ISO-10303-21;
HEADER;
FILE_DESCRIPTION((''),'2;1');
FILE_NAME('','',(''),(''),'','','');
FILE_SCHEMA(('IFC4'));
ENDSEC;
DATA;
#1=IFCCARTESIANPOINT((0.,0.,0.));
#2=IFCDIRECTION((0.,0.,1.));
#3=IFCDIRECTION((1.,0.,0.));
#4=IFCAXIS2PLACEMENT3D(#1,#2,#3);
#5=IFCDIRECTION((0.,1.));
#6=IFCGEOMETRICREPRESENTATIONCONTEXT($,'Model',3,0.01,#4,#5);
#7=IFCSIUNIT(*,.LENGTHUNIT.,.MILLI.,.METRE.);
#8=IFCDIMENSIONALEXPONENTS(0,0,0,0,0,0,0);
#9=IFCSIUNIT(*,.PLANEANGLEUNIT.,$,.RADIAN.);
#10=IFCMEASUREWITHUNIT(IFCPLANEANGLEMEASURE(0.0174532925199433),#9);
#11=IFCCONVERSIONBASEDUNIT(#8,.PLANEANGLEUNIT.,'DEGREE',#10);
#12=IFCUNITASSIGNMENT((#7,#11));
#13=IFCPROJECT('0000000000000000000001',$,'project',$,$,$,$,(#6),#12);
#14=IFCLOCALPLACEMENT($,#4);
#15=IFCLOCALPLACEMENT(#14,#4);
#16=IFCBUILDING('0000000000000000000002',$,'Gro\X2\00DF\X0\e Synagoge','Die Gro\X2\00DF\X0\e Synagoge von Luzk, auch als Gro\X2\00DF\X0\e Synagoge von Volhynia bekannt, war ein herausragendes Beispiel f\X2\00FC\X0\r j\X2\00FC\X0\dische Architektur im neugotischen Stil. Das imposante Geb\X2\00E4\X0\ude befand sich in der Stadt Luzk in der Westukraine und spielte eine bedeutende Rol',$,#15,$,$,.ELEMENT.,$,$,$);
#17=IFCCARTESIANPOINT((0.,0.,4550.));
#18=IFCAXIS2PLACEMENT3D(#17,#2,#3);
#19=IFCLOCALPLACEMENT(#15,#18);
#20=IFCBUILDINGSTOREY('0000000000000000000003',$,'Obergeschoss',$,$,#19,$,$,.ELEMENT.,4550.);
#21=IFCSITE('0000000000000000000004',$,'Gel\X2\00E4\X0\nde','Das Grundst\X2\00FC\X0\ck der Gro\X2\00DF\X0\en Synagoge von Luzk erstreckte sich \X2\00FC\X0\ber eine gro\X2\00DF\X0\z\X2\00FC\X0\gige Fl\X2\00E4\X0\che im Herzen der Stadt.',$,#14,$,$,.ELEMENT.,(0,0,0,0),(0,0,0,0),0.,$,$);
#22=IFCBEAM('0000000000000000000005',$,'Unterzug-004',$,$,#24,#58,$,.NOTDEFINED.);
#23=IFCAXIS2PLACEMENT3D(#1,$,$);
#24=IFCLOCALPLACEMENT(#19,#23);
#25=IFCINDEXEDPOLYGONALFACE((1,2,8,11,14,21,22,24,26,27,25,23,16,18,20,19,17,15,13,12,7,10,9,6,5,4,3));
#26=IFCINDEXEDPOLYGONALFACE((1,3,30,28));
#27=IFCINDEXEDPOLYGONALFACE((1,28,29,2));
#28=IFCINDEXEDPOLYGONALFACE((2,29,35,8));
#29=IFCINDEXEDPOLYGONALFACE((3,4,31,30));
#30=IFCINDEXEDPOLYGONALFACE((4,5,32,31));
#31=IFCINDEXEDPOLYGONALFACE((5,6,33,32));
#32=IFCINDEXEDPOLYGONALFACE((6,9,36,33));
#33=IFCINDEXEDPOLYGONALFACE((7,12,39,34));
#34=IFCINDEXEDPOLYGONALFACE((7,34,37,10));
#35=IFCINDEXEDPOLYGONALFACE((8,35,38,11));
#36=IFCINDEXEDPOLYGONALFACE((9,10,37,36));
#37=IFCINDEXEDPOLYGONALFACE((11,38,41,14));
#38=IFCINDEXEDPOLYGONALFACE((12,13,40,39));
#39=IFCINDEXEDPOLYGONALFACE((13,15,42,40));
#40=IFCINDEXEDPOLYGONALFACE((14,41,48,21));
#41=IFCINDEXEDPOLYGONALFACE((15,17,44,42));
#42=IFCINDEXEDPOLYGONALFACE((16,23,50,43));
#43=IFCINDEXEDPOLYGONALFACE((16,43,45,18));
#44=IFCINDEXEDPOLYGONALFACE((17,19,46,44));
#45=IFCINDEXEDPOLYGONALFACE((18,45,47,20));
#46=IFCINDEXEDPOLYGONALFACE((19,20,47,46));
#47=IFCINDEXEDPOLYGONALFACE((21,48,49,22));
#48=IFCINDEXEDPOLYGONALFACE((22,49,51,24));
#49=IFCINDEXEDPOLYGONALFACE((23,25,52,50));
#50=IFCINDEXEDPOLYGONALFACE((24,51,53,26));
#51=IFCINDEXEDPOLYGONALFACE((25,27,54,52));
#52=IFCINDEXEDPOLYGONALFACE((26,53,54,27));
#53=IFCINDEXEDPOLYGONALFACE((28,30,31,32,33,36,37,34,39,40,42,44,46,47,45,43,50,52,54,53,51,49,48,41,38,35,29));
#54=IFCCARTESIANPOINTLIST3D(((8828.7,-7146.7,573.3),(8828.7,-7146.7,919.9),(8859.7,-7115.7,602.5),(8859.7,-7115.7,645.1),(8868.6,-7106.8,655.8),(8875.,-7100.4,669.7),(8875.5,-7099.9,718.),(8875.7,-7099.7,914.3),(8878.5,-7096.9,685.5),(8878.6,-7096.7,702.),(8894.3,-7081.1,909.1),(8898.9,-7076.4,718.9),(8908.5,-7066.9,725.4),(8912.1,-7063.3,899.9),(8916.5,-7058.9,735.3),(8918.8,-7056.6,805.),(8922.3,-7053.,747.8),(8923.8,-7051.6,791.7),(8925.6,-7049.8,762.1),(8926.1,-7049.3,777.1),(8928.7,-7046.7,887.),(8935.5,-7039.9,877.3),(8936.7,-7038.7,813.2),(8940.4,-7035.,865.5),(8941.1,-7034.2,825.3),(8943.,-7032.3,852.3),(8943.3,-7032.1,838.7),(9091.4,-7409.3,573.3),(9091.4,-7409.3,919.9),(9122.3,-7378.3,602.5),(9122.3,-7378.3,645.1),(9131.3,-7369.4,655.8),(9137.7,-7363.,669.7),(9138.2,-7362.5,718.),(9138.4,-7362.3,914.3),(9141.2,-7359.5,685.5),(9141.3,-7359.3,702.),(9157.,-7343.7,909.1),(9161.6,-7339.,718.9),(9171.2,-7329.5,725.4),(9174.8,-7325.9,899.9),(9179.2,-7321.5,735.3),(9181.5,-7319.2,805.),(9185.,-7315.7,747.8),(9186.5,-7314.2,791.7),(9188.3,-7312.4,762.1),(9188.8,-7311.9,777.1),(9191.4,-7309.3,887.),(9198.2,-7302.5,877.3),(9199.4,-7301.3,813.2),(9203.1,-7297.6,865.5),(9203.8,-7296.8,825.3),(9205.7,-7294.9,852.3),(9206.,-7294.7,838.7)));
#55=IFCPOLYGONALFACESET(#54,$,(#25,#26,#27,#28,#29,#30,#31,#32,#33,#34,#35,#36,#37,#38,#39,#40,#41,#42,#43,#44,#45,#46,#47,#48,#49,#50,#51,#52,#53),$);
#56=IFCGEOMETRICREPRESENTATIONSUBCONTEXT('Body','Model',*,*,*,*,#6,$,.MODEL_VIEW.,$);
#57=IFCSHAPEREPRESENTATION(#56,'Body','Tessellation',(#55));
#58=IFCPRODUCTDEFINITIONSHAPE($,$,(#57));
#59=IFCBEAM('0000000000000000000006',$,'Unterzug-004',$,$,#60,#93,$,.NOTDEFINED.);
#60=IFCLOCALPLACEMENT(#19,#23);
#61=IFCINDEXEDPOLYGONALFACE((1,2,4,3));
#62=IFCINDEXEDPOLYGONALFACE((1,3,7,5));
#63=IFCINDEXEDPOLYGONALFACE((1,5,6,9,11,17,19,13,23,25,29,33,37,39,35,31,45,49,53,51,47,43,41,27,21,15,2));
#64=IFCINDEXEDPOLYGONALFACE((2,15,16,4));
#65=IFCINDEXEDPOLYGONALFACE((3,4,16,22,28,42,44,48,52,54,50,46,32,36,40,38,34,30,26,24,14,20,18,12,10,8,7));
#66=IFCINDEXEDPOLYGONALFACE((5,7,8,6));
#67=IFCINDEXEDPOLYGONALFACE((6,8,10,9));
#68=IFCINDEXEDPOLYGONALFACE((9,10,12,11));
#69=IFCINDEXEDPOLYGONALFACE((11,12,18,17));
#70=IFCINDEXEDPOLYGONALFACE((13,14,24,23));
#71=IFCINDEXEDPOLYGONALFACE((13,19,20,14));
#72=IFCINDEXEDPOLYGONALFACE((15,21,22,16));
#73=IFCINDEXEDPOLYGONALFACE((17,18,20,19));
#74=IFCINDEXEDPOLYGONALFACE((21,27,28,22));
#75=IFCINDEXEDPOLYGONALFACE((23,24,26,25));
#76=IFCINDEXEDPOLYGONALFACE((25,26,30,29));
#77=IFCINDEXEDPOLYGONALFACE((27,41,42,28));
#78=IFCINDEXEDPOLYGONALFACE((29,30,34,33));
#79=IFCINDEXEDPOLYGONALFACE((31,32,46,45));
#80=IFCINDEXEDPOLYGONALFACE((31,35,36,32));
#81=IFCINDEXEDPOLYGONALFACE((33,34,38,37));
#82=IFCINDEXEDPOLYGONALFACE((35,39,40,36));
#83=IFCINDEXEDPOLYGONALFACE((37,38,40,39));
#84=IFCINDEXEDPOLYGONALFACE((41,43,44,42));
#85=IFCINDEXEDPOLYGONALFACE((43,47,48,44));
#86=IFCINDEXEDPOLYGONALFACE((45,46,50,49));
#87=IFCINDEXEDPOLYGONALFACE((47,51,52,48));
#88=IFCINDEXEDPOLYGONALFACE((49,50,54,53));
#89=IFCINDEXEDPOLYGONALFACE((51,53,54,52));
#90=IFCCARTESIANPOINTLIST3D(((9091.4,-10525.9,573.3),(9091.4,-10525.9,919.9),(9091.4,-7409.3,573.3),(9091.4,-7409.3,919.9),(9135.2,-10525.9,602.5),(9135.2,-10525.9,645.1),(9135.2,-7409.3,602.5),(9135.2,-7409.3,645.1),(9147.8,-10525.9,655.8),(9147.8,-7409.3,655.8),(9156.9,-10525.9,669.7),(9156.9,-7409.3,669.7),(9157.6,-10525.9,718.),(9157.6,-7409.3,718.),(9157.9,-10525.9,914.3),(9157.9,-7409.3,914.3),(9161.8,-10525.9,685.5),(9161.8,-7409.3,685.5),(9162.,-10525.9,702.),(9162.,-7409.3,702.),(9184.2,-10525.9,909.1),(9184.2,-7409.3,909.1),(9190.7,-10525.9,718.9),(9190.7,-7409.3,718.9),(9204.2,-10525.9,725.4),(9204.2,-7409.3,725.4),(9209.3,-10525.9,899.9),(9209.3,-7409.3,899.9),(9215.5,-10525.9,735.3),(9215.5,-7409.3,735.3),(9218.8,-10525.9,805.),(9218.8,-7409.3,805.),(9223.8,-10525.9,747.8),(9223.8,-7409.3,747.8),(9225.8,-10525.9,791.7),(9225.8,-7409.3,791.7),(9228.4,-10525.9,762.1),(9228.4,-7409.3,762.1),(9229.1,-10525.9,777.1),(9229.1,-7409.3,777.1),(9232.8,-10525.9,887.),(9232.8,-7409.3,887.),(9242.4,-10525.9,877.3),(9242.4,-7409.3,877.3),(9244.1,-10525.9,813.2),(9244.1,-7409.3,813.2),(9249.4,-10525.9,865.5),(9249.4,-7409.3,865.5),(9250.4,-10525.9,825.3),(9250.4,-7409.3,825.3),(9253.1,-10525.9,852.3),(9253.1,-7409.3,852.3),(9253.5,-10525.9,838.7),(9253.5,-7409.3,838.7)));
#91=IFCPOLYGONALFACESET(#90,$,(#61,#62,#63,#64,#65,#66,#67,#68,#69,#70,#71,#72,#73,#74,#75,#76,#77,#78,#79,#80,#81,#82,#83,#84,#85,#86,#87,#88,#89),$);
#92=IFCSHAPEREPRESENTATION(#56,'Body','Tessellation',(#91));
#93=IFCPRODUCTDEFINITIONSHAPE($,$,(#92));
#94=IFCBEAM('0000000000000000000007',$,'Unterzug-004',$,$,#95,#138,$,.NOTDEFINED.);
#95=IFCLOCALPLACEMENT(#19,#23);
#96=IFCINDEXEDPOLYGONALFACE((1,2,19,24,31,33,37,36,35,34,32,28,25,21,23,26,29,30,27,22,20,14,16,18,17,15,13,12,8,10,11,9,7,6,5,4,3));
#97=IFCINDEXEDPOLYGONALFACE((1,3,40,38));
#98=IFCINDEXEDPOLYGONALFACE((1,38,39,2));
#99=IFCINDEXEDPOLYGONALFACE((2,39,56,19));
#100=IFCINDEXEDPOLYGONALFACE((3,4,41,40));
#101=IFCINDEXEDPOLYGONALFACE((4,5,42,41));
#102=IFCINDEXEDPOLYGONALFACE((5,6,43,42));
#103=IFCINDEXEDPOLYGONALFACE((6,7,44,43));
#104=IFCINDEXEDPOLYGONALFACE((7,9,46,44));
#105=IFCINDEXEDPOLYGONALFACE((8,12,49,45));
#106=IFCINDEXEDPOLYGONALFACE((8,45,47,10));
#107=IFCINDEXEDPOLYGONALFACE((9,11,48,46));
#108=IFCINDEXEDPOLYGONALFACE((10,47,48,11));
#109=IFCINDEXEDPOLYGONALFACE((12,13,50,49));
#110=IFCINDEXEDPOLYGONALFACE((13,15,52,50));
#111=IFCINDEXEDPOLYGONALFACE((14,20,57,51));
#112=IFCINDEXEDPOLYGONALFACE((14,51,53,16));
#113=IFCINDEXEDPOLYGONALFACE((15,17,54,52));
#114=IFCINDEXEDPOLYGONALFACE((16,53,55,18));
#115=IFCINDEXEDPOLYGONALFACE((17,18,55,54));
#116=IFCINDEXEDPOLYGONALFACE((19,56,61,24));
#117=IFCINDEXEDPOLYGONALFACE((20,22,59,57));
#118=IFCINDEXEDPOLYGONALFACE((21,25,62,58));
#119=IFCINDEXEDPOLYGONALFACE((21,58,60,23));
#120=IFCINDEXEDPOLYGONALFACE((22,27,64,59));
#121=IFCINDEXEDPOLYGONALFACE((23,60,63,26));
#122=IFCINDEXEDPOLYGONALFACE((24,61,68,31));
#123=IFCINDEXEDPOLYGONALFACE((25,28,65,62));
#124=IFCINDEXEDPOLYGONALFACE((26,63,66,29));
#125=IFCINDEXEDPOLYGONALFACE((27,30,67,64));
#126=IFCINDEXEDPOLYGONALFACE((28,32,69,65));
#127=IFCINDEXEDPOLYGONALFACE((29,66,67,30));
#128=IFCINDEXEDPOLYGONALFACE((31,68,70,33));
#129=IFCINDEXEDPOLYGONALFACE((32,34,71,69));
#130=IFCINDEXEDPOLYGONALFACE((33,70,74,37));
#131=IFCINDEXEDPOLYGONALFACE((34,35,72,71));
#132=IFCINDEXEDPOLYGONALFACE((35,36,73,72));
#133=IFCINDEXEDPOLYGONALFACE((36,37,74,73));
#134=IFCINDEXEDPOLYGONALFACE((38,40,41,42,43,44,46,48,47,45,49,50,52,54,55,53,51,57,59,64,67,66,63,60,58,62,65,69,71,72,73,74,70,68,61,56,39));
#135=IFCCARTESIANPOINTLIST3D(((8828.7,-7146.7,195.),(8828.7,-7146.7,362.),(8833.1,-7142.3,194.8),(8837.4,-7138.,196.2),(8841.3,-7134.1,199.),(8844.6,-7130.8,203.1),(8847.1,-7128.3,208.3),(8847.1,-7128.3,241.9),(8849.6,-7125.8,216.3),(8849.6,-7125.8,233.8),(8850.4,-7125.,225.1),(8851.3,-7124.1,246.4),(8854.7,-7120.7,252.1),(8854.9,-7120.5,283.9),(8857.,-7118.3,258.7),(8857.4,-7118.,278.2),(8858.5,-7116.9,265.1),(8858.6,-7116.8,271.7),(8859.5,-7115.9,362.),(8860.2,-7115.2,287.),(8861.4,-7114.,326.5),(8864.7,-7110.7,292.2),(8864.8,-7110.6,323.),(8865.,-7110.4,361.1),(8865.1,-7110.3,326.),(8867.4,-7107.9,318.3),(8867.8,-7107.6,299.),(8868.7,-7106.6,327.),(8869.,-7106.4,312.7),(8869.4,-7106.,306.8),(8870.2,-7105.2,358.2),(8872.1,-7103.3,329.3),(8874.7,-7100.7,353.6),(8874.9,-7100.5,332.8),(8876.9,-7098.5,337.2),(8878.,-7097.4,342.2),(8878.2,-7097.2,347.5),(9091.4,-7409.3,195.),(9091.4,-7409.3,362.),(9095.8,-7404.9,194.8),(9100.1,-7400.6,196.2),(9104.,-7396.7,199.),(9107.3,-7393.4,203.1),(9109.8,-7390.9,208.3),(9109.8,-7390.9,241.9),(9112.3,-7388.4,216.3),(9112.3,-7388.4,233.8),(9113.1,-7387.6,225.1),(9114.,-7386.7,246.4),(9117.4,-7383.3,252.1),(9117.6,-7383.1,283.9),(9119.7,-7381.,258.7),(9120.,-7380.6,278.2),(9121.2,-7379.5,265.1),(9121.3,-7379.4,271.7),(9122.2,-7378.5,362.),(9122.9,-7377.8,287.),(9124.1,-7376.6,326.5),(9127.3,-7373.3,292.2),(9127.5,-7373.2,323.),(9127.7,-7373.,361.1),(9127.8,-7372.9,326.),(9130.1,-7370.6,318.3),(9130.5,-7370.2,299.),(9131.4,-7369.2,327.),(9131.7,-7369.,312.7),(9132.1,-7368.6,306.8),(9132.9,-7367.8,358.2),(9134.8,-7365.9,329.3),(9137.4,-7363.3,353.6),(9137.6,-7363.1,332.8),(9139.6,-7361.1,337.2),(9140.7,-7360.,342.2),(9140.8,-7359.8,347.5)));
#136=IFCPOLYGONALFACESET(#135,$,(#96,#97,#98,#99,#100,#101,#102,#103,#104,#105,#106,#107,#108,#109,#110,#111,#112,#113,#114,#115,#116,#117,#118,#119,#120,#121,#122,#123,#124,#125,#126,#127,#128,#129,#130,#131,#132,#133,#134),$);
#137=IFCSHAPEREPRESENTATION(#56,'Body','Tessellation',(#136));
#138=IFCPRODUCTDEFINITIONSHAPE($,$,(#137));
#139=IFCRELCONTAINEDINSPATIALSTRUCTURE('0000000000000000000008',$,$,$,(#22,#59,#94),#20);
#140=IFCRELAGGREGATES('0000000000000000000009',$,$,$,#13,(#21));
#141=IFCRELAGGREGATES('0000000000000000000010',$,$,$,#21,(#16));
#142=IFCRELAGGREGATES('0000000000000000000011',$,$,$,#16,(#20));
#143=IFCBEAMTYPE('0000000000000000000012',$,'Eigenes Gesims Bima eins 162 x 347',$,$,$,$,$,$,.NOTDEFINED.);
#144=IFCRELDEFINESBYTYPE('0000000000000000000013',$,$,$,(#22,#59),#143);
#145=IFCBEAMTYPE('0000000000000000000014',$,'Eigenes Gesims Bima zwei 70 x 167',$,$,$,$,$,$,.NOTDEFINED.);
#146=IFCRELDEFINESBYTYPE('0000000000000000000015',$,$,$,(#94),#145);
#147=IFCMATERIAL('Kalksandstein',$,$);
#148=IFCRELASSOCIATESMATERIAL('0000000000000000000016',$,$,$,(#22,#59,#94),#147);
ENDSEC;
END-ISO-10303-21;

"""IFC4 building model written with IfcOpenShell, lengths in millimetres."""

from ifc_helpers import new_model, entity, si_unit, converted_unit, direction, frame, origin_with_axes, place, context, subcontext, project, spatial, line, arc, indexed_curve, outline, extrude, material, material_profile, profile_set, type_object, element, save


model = new_model("IFC4")

# Units and contexts
model_context = context("Model", 3, precision=0.01, world=origin_with_axes(), true_north=direction((0.0, 1.0)))
body_context = subcontext(model_context, "Body", "Model", "MODEL_VIEW")
ifc_project = project(units=[si_unit("LENGTHUNIT", "METRE", prefix="MILLI"), converted_unit("PLANEANGLEUNIT", "DEGREE", entity("IfcPlaneAngleMeasure", 0.0174532925199433), si_unit("PLANEANGLEUNIT", "RADIAN"), dimensions=[0, 0, 0, 0, 0, 0, 0])], contexts=[model_context])

# Site, building, storey
site_placement = place(None, origin_with_axes())
site = spatial("IfcSite", under=ifc_project, at=site_placement, Name="Gelände", Description="Das Grundstück der Großen Synagoge von Luzk erstreckte sich über eine großzügige Fläche im Herzen der Stadt.", CompositionType="ELEMENT", RefLatitude=(0, 0, 0, 0), RefLongitude=(0, 0, 0, 0), RefElevation=0.0)
building_placement = place(site_placement, origin_with_axes())
building = spatial("IfcBuilding", under=site, at=building_placement, Name="Große Synagoge", Description="Die Große Synagoge von Luzk, auch als Große Synagoge von Volhynia bekannt, war ein herausragendes Beispiel für jüdische Architektur im neugotischen Stil. Das imposante Gebäude befand sich in der Stadt Luzk in der Westukraine und spielte eine bedeutende Rol", CompositionType="ELEMENT")
storey_placement = place(building_placement, frame((0.0, 0.0, 4550.0), z_axis=(0.0, 0.0, 1.0), x_axis=(1.0, 0.0, 0.0)))
storey = spatial("IfcBuildingStorey", under=building, at=storey_placement, Name="Obergeschoss", CompositionType="ELEMENT", Elevation=4550.0)

# Beams
ifc_material_1 = material(Name="Kalksandstein")
ifc_material_profile_1 = material_profile(ifc_material_1, outline(indexed_curve([(127.4, -114.9), (152.7, -106.7), (161.7, -67.6), (141.4, -32.9), (105.5, -14.9), (66.5, -5.6), (0.0, 0.0), (0.0, -346.6), (43.7, -317.4), (43.7, -274.8), (68.5, -242.5), (66.2, -201.9), (99.3, -201.0), (135.2, -165.1)], segments=[line(1, 2), arc(2, 3, 4), arc(4, 5, 6), line(6, 7, 8, 9, 10), arc(10, 11, 12), line(12, 13), arc(13, 14, 1)])), Name="Kalksandstein")
ifc_profile_set_1 = profile_set([ifc_material_profile_1], Name="Eigenes Gesims Bima eins")
beam_type_1 = type_object("IfcBeamType", Name="Eigenes Gesims Bima eins 162 x 347", PredefinedType="NOTDEFINED")
beam_1_placement = place(storey_placement, frame((9091.4, -7409.3, 919.9), z_axis=(0.0, 0.0, 1.0), x_axis=(0.706994, 0.707219, 0.0)))
element("IfcBeam", 1, at=beam_1_placement, inside=storey, type_object=beam_type_1, material=ifc_profile_set_1, Name="Unterzug-004", PredefinedType="NOTDEFINED", context=body_context, shape_type="SweptSolid", body=[
    extrude(outline(indexed_curve([(127.4, -114.9), (152.7, -106.7), (161.7, -67.6), (141.4, -32.9), (105.5, -14.9), (66.5, -5.6), (0.0, 0.0), (0.0, -346.6), (43.7, -317.4), (43.7, -274.8), (68.5, -242.5), (66.2, -201.9), (99.3, -201.0), (135.2, -165.1)], segments=[line(1, 2), arc(2, 3, 4), arc(4, 5, 6), line(6, 7, 8, 9, 10), arc(10, 11, 12), line(12, 13), arc(13, 14, 1)])), frame((0.0, 371.4, 0.0), z_axis=(0.0, -1.0, 0.0), x_axis=(1.0, 0.0, 0.0)), (0.0, 0.0, 1.0), 371.4),
])
beam_2_placement = place(storey_placement, frame((9091.4, -10525.9, 919.9), z_axis=(0.0, 0.0, 1.0), x_axis=(1.0, 0.0, 0.0)))
element("IfcBeam", 2, at=beam_2_placement, inside=storey, type_object=beam_type_1, material=ifc_profile_set_1, Name="Unterzug-004", PredefinedType="NOTDEFINED", context=body_context, shape_type="SweptSolid", body=[
    extrude(outline(indexed_curve([(127.4, -114.9), (152.7, -106.7), (161.7, -67.6), (141.4, -32.9), (105.5, -14.9), (66.5, -5.6), (0.0, 0.0), (0.0, -346.6), (43.7, -317.4), (43.7, -274.8), (68.5, -242.5), (66.2, -201.9), (99.3, -201.0), (135.2, -165.1)], segments=[line(1, 2), arc(2, 3, 4), arc(4, 5, 6), line(6, 7, 8, 9, 10), arc(10, 11, 12), line(12, 13), arc(13, 14, 1)])), frame((0.0, 3116.6, 0.0), z_axis=(0.0, -1.0, 0.0), x_axis=(1.0, 0.0, 0.0)), (0.0, 0.0, 1.0), 3116.6),
])
ifc_material_profile_2 = material_profile(ifc_material_1, outline(indexed_curve([(40.0, -103.3), (42.2, -90.2), (37.0, -78.1), (50.8, -69.8), (57.6, -55.2), (54.7, -43.7), (46.2, -35.5), (63.4, -31.1), (69.9, -14.5), (58.6, -3.7), (43.5, 0.0), (0.0, 0.0), (0.0, -167.0), (15.1, -164.6), (26.0, -153.7), (30.7, -136.9), (26.0, -120.0), (34.5, -112.9)], segments=[arc(1, 2, 3), arc(3, 4, 5), arc(5, 6, 7), arc(7, 8, 9), arc(9, 10, 11), line(11, 12, 13), arc(13, 14, 15), arc(15, 16, 17), arc(17, 18, 1)])), Name="Kalksandstein")
ifc_profile_set_2 = profile_set([ifc_material_profile_2], Name="Eigenes Gesims Bima zwei")
beam_type_2 = type_object("IfcBeamType", Name="Eigenes Gesims Bima zwei 70 x 167", PredefinedType="NOTDEFINED")
beam_3_placement = place(storey_placement, frame((9091.4, -7409.3, 362.0), z_axis=(0.0, 0.0, 1.0), x_axis=(0.706994, 0.707219, 0.0)))
element("IfcBeam", 3, at=beam_3_placement, inside=storey, type_object=beam_type_2, material=ifc_profile_set_2, Name="Unterzug-004", PredefinedType="NOTDEFINED", context=body_context, shape_type="SweptSolid", body=[
    extrude(outline(indexed_curve([(40.0, -103.3), (42.2, -90.2), (37.0, -78.1), (50.8, -69.8), (57.6, -55.2), (54.7, -43.7), (46.2, -35.5), (63.4, -31.1), (69.9, -14.5), (58.6, -3.7), (43.5, 0.0), (0.0, 0.0), (0.0, -167.0), (15.1, -164.6), (26.0, -153.7), (30.7, -136.9), (26.0, -120.0), (34.5, -112.9)], segments=[arc(1, 2, 3), arc(3, 4, 5), arc(5, 6, 7), arc(7, 8, 9), arc(9, 10, 11), line(11, 12, 13), arc(13, 14, 15), arc(15, 16, 17), arc(17, 18, 1)])), frame((0.0, 371.4, 0.0), z_axis=(0.0, -1.0, 0.0), x_axis=(1.0, 0.0, 0.0)), (0.0, 0.0, 1.0), 371.4),
])

save(model, "model.ifc")
